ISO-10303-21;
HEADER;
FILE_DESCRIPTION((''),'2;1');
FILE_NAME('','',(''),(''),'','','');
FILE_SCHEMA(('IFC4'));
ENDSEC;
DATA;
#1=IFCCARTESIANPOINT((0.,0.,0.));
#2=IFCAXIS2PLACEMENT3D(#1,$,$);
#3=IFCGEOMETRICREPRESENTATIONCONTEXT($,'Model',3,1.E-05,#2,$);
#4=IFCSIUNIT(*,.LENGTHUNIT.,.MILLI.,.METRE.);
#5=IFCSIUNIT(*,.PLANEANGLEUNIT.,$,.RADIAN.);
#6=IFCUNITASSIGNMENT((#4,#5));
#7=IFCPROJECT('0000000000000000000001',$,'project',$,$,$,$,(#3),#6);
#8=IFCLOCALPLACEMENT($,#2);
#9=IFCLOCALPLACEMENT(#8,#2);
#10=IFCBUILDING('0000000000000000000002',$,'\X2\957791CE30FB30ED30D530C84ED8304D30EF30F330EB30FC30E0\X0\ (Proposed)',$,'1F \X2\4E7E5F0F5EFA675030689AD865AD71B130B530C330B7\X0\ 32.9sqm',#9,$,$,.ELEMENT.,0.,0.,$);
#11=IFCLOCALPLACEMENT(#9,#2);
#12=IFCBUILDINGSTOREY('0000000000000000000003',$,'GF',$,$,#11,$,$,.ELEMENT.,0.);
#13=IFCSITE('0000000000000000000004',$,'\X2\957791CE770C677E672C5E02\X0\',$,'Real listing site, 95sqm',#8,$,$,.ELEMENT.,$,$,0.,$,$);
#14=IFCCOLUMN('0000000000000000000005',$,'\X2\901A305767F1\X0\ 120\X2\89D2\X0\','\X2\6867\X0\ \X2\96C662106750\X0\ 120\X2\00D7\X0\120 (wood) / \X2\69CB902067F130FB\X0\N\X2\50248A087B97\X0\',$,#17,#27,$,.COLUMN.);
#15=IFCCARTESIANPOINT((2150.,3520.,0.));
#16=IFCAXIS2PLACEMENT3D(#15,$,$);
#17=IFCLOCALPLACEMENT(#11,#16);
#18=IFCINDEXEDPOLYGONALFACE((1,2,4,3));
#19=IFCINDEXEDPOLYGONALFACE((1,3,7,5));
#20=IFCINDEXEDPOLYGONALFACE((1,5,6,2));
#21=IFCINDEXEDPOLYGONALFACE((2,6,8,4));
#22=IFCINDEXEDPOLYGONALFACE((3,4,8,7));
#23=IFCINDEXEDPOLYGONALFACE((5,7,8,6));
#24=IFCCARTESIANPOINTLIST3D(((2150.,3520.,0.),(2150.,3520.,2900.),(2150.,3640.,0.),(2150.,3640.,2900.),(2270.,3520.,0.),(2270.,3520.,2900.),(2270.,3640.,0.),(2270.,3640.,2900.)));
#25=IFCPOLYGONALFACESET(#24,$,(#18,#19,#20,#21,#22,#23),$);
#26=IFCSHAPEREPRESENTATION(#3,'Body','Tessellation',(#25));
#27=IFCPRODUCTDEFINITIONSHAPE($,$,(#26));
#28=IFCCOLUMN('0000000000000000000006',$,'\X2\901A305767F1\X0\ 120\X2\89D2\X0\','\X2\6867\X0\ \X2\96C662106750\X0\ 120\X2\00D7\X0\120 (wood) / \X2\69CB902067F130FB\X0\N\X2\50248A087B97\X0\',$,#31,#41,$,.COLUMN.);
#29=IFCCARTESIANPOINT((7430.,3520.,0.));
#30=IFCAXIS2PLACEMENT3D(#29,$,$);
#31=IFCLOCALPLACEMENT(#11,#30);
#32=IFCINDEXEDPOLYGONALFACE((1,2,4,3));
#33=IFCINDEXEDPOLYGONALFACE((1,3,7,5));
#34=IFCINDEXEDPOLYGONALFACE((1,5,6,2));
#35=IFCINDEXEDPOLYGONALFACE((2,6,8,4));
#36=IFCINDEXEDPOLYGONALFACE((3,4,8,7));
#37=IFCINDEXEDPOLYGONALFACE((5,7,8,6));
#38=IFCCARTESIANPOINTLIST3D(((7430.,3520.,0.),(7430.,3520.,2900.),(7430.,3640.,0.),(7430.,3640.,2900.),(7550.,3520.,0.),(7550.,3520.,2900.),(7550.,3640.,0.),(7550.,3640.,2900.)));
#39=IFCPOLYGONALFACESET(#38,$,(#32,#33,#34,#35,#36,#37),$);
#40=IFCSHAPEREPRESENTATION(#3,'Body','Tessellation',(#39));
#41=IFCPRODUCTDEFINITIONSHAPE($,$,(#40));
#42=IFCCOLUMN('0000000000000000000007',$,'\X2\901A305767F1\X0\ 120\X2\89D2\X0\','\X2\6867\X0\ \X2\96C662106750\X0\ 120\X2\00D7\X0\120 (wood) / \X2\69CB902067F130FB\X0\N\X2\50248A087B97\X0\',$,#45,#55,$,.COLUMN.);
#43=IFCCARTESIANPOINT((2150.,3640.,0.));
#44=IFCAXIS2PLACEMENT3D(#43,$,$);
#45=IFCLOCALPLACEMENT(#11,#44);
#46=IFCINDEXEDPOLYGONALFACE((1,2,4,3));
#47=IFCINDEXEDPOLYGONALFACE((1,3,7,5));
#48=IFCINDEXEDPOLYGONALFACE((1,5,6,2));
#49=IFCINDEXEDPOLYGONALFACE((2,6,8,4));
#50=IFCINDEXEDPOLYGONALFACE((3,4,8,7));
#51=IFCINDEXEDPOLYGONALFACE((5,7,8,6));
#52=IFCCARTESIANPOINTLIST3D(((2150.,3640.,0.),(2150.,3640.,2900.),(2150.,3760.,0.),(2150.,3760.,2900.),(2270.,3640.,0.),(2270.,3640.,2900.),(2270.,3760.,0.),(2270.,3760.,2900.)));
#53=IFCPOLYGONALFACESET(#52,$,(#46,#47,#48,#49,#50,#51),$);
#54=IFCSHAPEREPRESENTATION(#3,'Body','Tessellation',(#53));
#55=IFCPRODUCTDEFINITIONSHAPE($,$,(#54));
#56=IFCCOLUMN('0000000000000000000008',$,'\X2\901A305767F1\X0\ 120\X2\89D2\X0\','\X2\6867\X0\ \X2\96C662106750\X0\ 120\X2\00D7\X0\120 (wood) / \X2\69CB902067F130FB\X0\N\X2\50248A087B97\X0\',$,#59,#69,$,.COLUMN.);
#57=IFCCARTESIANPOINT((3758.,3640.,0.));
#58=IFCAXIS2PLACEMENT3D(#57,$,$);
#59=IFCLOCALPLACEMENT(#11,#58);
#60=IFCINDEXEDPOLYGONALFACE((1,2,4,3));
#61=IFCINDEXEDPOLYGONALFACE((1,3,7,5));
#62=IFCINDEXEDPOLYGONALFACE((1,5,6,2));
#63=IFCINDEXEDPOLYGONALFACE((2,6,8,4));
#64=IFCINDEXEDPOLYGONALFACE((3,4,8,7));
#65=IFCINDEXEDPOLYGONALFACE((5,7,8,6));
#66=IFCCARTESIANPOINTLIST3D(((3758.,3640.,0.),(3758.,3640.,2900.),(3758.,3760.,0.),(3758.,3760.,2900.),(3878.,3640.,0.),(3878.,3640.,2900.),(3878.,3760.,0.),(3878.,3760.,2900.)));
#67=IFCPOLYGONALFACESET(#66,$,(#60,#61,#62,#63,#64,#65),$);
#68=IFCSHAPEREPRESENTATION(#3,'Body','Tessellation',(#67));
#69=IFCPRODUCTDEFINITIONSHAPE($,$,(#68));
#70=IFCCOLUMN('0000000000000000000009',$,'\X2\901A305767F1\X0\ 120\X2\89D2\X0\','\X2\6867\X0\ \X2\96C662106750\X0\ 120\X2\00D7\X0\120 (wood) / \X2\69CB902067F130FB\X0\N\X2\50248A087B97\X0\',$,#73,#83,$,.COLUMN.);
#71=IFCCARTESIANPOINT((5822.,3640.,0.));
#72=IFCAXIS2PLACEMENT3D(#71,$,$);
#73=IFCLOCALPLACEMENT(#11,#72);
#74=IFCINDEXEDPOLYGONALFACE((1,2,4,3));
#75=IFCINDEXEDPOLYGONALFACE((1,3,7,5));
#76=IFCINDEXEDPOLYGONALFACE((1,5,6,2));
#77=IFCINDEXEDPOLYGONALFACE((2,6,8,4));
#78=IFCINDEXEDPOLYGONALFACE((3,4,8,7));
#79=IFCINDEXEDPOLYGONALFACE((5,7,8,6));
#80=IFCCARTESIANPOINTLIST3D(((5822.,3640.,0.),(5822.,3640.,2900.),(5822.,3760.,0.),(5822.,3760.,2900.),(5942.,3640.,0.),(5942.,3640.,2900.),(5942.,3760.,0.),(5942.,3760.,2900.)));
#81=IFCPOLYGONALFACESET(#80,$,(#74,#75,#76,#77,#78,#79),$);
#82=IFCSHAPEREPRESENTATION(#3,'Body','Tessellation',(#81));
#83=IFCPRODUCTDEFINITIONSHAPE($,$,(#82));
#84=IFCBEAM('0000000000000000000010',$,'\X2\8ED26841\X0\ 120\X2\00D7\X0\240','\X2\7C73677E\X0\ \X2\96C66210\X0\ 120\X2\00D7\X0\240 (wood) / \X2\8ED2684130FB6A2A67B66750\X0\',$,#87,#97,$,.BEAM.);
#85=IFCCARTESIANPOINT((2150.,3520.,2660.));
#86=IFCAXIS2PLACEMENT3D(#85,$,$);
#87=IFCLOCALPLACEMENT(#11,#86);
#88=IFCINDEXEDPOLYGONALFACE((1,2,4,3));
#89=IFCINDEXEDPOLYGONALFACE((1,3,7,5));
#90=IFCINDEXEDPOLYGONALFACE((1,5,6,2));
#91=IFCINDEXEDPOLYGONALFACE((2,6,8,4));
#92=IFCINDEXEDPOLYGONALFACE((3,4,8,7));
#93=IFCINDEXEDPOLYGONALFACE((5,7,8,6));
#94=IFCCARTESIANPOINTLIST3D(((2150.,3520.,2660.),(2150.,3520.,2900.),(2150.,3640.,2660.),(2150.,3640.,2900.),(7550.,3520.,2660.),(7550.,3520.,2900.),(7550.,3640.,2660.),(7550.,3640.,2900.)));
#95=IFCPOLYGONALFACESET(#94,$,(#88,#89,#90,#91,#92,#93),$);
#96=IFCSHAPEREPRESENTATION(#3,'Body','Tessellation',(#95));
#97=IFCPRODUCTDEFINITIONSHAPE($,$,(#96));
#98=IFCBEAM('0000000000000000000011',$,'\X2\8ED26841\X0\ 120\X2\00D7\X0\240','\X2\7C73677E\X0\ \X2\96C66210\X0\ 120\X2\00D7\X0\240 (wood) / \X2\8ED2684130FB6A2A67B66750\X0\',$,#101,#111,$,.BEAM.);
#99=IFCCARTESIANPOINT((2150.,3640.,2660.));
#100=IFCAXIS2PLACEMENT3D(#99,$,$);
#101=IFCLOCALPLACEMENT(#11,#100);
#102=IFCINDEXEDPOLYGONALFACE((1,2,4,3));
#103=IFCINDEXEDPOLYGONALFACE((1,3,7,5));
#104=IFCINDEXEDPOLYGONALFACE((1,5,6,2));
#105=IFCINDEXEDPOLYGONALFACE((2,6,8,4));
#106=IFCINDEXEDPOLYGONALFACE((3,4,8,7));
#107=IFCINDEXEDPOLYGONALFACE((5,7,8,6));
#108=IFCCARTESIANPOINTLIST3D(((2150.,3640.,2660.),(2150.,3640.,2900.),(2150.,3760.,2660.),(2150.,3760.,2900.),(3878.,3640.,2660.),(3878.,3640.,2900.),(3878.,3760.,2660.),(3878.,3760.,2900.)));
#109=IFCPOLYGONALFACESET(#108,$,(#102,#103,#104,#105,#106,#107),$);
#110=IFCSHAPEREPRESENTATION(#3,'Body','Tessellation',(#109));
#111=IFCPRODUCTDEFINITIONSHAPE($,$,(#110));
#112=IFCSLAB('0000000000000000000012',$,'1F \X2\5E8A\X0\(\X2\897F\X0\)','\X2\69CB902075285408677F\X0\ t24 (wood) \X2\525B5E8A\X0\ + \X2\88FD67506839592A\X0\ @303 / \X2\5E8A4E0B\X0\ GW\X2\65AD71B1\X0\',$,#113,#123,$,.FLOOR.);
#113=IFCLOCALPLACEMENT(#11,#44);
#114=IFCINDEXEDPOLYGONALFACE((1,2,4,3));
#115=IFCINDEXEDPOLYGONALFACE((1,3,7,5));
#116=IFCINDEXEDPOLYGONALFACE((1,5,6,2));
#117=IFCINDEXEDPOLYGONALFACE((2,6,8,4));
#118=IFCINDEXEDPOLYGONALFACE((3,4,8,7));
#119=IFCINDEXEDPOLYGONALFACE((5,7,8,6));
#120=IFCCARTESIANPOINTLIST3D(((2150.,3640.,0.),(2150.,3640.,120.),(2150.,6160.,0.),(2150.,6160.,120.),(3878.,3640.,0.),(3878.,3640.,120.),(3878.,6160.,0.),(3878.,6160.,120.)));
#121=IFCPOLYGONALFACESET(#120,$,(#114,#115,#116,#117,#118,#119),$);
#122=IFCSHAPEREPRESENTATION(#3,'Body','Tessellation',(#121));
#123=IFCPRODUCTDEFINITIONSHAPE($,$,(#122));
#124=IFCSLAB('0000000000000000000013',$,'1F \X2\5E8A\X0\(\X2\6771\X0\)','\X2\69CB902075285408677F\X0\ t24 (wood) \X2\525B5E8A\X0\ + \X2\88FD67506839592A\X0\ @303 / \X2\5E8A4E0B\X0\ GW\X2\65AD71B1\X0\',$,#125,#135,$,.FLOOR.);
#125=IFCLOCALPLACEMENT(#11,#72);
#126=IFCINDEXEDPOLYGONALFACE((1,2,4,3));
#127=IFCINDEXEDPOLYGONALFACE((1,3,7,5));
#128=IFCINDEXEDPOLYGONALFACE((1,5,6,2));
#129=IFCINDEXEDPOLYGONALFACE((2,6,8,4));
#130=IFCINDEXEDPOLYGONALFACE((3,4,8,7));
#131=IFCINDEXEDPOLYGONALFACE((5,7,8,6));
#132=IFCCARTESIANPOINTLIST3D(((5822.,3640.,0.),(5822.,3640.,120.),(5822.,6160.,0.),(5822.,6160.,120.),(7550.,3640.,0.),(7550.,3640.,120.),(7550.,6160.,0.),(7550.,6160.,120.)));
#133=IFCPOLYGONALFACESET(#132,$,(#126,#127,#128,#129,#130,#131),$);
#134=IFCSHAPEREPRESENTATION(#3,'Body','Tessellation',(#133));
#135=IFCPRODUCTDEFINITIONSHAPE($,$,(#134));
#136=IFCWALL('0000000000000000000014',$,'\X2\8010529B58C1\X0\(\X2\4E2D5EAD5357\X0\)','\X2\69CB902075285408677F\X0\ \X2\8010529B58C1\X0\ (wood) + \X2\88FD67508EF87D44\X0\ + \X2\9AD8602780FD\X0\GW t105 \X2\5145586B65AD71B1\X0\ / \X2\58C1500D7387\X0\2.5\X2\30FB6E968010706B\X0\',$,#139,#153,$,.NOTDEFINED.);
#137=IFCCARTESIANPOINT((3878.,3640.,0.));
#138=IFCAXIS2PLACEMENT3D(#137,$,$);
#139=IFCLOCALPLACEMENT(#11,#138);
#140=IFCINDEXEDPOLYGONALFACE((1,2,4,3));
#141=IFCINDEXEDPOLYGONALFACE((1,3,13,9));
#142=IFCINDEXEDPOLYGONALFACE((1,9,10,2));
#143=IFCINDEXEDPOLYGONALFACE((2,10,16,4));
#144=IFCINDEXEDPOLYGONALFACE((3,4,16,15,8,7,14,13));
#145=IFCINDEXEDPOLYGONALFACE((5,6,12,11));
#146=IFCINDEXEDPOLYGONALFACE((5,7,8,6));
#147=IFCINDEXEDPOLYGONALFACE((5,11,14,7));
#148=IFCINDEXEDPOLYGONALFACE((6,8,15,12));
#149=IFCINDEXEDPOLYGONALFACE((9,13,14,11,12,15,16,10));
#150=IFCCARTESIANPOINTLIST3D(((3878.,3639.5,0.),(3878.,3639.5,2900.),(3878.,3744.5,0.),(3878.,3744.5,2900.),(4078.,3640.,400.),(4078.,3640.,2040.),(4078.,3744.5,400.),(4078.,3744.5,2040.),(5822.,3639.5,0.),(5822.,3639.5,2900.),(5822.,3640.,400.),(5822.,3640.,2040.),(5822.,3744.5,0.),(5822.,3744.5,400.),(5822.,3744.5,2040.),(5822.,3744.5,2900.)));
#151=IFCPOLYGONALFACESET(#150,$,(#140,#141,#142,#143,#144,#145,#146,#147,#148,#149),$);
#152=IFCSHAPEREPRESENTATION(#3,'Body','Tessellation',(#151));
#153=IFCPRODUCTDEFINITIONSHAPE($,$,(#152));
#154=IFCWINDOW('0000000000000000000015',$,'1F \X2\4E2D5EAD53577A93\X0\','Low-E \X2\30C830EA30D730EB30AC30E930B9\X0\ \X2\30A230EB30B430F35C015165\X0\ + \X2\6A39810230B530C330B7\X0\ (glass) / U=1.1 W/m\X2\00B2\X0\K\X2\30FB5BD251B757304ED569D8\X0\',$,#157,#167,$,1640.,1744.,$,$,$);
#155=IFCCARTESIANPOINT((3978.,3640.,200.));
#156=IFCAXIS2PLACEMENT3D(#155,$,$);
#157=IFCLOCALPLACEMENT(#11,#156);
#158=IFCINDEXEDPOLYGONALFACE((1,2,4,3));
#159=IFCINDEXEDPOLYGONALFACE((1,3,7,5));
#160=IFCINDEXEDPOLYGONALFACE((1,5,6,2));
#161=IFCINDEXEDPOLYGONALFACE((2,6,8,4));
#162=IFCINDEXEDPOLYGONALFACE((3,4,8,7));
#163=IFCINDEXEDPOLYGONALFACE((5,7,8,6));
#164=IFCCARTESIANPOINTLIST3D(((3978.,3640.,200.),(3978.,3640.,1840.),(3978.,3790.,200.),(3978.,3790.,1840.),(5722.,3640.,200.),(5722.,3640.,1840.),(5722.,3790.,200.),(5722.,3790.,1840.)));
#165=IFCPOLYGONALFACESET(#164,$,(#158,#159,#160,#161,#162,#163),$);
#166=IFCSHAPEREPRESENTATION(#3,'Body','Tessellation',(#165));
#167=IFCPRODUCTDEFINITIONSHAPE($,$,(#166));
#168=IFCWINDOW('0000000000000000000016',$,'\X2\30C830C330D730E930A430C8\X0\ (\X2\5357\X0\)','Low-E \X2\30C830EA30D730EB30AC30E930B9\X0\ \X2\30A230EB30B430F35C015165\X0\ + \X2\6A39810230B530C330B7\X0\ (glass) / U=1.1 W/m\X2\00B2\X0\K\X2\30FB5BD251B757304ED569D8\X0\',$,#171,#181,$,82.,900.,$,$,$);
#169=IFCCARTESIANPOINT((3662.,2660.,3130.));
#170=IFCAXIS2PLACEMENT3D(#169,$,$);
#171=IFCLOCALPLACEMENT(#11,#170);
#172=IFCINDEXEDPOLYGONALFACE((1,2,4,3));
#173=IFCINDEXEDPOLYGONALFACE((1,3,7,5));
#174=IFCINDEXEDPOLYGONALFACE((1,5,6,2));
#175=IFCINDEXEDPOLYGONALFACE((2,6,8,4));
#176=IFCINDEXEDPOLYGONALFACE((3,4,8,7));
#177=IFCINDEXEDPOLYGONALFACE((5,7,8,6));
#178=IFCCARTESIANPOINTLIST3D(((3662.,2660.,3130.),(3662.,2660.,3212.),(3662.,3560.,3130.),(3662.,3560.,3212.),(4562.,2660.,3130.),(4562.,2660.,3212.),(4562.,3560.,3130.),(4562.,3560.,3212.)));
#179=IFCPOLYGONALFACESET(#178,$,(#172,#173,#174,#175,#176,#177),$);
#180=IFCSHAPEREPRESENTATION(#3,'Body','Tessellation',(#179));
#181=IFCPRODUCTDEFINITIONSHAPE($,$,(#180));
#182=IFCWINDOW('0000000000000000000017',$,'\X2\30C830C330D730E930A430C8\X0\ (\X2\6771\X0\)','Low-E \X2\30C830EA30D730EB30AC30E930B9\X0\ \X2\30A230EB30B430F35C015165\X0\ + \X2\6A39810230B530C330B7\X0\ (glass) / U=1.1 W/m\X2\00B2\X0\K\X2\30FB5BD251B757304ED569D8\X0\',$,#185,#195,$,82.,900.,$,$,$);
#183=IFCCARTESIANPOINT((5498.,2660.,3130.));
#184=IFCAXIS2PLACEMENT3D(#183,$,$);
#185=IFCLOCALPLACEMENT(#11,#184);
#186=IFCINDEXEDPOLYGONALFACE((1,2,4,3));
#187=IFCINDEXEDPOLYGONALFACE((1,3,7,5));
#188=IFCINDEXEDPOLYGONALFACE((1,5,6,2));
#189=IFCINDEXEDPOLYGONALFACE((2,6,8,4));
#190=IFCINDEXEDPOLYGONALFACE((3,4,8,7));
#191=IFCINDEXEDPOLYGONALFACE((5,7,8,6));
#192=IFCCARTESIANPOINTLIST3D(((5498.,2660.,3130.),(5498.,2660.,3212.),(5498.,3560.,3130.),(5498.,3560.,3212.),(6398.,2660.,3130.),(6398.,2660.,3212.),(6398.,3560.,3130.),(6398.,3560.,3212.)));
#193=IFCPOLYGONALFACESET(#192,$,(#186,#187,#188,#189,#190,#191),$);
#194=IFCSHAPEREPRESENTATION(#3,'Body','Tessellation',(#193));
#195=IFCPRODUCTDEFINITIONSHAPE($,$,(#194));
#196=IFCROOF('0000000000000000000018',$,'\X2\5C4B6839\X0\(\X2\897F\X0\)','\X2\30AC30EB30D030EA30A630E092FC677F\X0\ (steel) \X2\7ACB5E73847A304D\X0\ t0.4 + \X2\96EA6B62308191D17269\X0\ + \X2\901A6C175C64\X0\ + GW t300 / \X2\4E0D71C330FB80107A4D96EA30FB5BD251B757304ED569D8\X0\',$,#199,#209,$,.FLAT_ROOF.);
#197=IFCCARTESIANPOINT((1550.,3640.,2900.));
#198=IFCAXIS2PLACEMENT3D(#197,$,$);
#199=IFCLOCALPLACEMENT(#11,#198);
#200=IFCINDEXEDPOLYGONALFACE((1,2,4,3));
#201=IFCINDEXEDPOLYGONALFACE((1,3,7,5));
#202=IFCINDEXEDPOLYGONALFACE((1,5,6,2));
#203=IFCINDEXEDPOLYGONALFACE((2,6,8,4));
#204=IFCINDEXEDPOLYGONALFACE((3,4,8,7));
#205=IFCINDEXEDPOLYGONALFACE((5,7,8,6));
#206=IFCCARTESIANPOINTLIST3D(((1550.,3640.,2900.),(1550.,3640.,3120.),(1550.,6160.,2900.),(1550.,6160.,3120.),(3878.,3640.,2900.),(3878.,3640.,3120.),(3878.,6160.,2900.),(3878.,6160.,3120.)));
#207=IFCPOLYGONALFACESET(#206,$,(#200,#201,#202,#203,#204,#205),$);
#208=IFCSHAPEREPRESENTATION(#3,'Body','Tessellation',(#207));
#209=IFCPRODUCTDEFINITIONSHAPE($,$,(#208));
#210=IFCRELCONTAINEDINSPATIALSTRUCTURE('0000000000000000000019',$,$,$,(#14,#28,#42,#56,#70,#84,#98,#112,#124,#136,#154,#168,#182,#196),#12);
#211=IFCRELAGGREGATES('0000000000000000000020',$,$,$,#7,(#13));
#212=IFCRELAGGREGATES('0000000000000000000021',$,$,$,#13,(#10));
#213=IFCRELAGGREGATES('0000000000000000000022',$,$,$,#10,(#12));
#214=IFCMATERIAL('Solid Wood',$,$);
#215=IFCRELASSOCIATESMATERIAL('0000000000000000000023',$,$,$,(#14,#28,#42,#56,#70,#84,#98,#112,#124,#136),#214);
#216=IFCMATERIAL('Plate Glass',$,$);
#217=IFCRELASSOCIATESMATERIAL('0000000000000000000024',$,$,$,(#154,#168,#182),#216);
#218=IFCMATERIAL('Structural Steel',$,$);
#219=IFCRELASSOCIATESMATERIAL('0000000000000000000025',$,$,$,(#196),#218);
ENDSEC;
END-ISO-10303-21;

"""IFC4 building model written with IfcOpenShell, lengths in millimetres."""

from ifc_helpers import new_model, si_unit, frame, frame_2d, origin, place, context, project, spatial, rectangle, extrude, material, element, fill, save


model = new_model("IFC4")

# Units and contexts
model_context = context("Model", 3, precision=1e-05, world=origin())
ifc_project = project(units=[si_unit("LENGTHUNIT", "METRE", prefix="MILLI"), si_unit("PLANEANGLEUNIT", "RADIAN")], contexts=[model_context])

# Site, building, storey
site_placement = place(None, origin())
site = spatial("IfcSite", under=ifc_project, at=site_placement, Name="長野県松本市", ObjectType="Real listing site, 95sqm", CompositionType="ELEMENT", RefElevation=0.0)
building_placement = place(site_placement, origin())
building = spatial("IfcBuilding", under=site, at=building_placement, Name="長野・ロフト付きワンルーム (Proposed)", ObjectType="1F 乾式建材と高断熱サッシ 32.9sqm", CompositionType="ELEMENT", ElevationOfRefHeight=0.0, ElevationOfTerrain=0.0)
storey_placement = place(building_placement, origin())
storey = spatial("IfcBuildingStorey", under=building, at=storey_placement, Name="GF", CompositionType="ELEMENT", Elevation=0.0)

# Columns
ifc_material_1 = material(Name="Solid Wood")
column_1_placement = place(storey_placement, frame((2150.0, 3520.0, 0.0)))
element("IfcColumn", 1, at=column_1_placement, inside=storey, material=ifc_material_1, Name="通し柱 120角", Description="桧 集成材 120×120 (wood) / 構造柱・N値計算", PredefinedType="COLUMN", context=model_context, shape_type="SweptSolid", body=[
    extrude(rectangle(XDim=120.0, YDim=120.0, at=frame_2d((60.0, 60.0))), frame((2150.0, 3520.0, 0.0)), (0.0, 0.0, 1.0), 2900.0),
])
column_2_placement = place(storey_placement, frame((7430.0, 3520.0, 0.0)))
element("IfcColumn", 2, at=column_2_placement, inside=storey, material=ifc_material_1, Name="通し柱 120角", Description="桧 集成材 120×120 (wood) / 構造柱・N値計算", PredefinedType="COLUMN", context=model_context, shape_type="SweptSolid", body=[
    extrude(rectangle(XDim=120.0, YDim=120.0, at=frame_2d((60.0, 60.0))), frame((7430.0, 3520.0, 0.0)), (0.0, 0.0, 1.0), 2900.0),
])
column_3_placement = place(storey_placement, frame((2150.0, 3640.0, 0.0)))
element("IfcColumn", 3, at=column_3_placement, inside=storey, material=ifc_material_1, Name="通し柱 120角", Description="桧 集成材 120×120 (wood) / 構造柱・N値計算", PredefinedType="COLUMN", context=model_context, shape_type="SweptSolid", body=[
    extrude(rectangle(XDim=120.0, YDim=120.0, at=frame_2d((60.0, 60.0))), frame((2150.0, 3640.0, 0.0)), (0.0, 0.0, 1.0), 2900.0),
])
column_4_placement = place(storey_placement, frame((3758.0, 3640.0, 0.0)))
element("IfcColumn", 4, at=column_4_placement, inside=storey, material=ifc_material_1, Name="通し柱 120角", Description="桧 集成材 120×120 (wood) / 構造柱・N値計算", PredefinedType="COLUMN", context=model_context, shape_type="SweptSolid", body=[
    extrude(rectangle(XDim=120.0, YDim=120.0, at=frame_2d((60.0, 60.0))), frame((3758.0, 3640.0, 0.0)), (0.0, 0.0, 1.0), 2900.0),
])
column_5_placement = place(storey_placement, frame((5822.0, 3640.0, 0.0)))
element("IfcColumn", 5, at=column_5_placement, inside=storey, material=ifc_material_1, Name="通し柱 120角", Description="桧 集成材 120×120 (wood) / 構造柱・N値計算", PredefinedType="COLUMN", context=model_context, shape_type="SweptSolid", body=[
    extrude(rectangle(XDim=120.0, YDim=120.0, at=frame_2d((60.0, 60.0))), frame((5822.0, 3640.0, 0.0)), (0.0, 0.0, 1.0), 2900.0),
])

# Beams
beam_1_placement = place(storey_placement, frame((2150.0, 3520.0, 2660.0)))
element("IfcBeam", 6, at=beam_1_placement, inside=storey, material=ifc_material_1, Name="軒桁 120×240", Description="米松 集成 120×240 (wood) / 軒桁・横架材", PredefinedType="BEAM", context=model_context, shape_type="SweptSolid", body=[
    extrude(rectangle(XDim=5400.0, YDim=120.0, at=frame_2d((2700.0, 60.0))), frame((2150.0, 3520.0, 2660.0)), (0.0, 0.0, 1.0), 240.0),
])
beam_2_placement = place(storey_placement, frame((2150.0, 3640.0, 2660.0)))
element("IfcBeam", 7, at=beam_2_placement, inside=storey, material=ifc_material_1, Name="軒桁 120×240", Description="米松 集成 120×240 (wood) / 軒桁・横架材", PredefinedType="BEAM", context=model_context, shape_type="SweptSolid", body=[
    extrude(rectangle(XDim=1728.0, YDim=120.0, at=frame_2d((864.0, 60.0))), frame((2150.0, 3640.0, 2660.0)), (0.0, 0.0, 1.0), 240.0),
])

# Slabs
slab_1_placement = place(storey_placement, frame((2150.0, 3640.0, 0.0)))
element("IfcSlab", 8, at=slab_1_placement, inside=storey, material=ifc_material_1, Name="1F 床(西)", Description="構造用合板 t24 (wood) 剛床 + 製材根太 @303 / 床下 GW断熱", PredefinedType="FLOOR", context=model_context, shape_type="SweptSolid", body=[
    extrude(rectangle(XDim=1728.0, YDim=2520.0, at=frame_2d((864.0, 1260.0))), frame((2150.0, 3640.0, 0.0)), (0.0, 0.0, 1.0), 120.0),
])
slab_2_placement = place(storey_placement, frame((5822.0, 3640.0, 0.0)))
element("IfcSlab", 9, at=slab_2_placement, inside=storey, material=ifc_material_1, Name="1F 床(東)", Description="構造用合板 t24 (wood) 剛床 + 製材根太 @303 / 床下 GW断熱", PredefinedType="FLOOR", context=model_context, shape_type="SweptSolid", body=[
    extrude(rectangle(XDim=1728.0, YDim=2520.0, at=frame_2d((864.0, 1260.0))), frame((5822.0, 3640.0, 0.0)), (0.0, 0.0, 1.0), 120.0),
])

# Wall, opening, window
wall_1_placement = place(storey_placement, frame((3878.0, 3640.0, 0.0)))
wall_1 = element("IfcWall", 10, at=wall_1_placement, inside=storey, material=ifc_material_1, Name="耐力壁(中庭南)", Description="構造用合板 耐力壁 (wood) + 製材軸組 + 高性能GW t105 充填断熱 / 壁倍率2.5・準耐火", PredefinedType="NOTDEFINED", context=model_context, shape_type="SweptSolid", body=[
    extrude(rectangle(XDim=1944.0, YDim=105.0, at=frame_2d((972.0, 52.0))), frame((3878.0, 3640.0, 0.0)), (0.0, 0.0, 1.0), 2900.0),
])
opening_placement = place(storey_placement, frame((3978.0, 3640.0, 200.0)))
opening = element("IfcOpeningElement", 11, at=opening_placement, cuts=wall_1, PredefinedType="NOTDEFINED", context=model_context, shape_type="SweptSolid", body=[
    extrude(rectangle(XDim=1744.0, YDim=150.0, at=frame_2d((872.0, 75.0))), frame((3978.0, 3640.0, 200.0)), (0.0, 0.0, 1.0), 1640.0),
])
ifc_material_2 = material(Name="Plate Glass")
window_1_placement = place(storey_placement, frame((3978.0, 3640.0, 200.0)))
window_1 = element("IfcWindow", 12, at=window_1_placement, inside=storey, material=ifc_material_2, Name="1F 中庭南窓", Description="Low-E トリプルガラス アルゴン封入 + 樹脂サッシ (glass) / U=1.1 W/m²K・寒冷地仕様", OverallHeight=1640.0, OverallWidth=1744.0, context=model_context, shape_type="SweptSolid", body=[
    extrude(rectangle(XDim=1744.0, YDim=150.0, at=frame_2d((872.0, 75.0))), frame((3978.0, 3640.0, 200.0)), (0.0, 0.0, 1.0), 1640.0),
])
fill(opening, window_1)

# Windows
window_2_placement = place(storey_placement, frame((3662.0, 2660.0, 3130.0)))
element("IfcWindow", 13, at=window_2_placement, inside=storey, material=ifc_material_2, Name="トップライト (南)", Description="Low-E トリプルガラス アルゴン封入 + 樹脂サッシ (glass) / U=1.1 W/m²K・寒冷地仕様", OverallHeight=82.0, OverallWidth=900.0, context=model_context, shape_type="SweptSolid", body=[
    extrude(rectangle(XDim=900.0, YDim=900.0, at=frame_2d((450.0, 450.0))), frame((3662.0, 2660.0, 3130.0)), (0.0, 0.0, 1.0), 82.0),
])
window_3_placement = place(storey_placement, frame((5498.0, 2660.0, 3130.0)))
element("IfcWindow", 14, at=window_3_placement, inside=storey, material=ifc_material_2, Name="トップライト (東)", Description="Low-E トリプルガラス アルゴン封入 + 樹脂サッシ (glass) / U=1.1 W/m²K・寒冷地仕様", OverallHeight=82.0, OverallWidth=900.0, context=model_context, shape_type="SweptSolid", body=[
    extrude(rectangle(XDim=900.0, YDim=900.0, at=frame_2d((450.0, 450.0))), frame((5498.0, 2660.0, 3130.0)), (0.0, 0.0, 1.0), 82.0),
])

# Roof
ifc_material_3 = material(Name="Structural Steel")
roof_1_placement = place(storey_placement, frame((1550.0, 3640.0, 2900.0)))
element("IfcRoof", 15, at=roof_1_placement, inside=storey, material=ifc_material_3, Name="屋根(西)", Description="ガルバリウム鋼板 (steel) 立平葺き t0.4 + 雪止め金物 + 通気層 + GW t300 / 不燃・耐積雪・寒冷地仕様", PredefinedType="FLAT_ROOF", context=model_context, shape_type="SweptSolid", body=[
    extrude(rectangle(XDim=2328.0, YDim=2520.0, at=frame_2d((1164.0, 1260.0))), frame((1550.0, 3640.0, 2900.0)), (0.0, 0.0, 1.0), 220.0),
])

save(model, "model.ifc")
